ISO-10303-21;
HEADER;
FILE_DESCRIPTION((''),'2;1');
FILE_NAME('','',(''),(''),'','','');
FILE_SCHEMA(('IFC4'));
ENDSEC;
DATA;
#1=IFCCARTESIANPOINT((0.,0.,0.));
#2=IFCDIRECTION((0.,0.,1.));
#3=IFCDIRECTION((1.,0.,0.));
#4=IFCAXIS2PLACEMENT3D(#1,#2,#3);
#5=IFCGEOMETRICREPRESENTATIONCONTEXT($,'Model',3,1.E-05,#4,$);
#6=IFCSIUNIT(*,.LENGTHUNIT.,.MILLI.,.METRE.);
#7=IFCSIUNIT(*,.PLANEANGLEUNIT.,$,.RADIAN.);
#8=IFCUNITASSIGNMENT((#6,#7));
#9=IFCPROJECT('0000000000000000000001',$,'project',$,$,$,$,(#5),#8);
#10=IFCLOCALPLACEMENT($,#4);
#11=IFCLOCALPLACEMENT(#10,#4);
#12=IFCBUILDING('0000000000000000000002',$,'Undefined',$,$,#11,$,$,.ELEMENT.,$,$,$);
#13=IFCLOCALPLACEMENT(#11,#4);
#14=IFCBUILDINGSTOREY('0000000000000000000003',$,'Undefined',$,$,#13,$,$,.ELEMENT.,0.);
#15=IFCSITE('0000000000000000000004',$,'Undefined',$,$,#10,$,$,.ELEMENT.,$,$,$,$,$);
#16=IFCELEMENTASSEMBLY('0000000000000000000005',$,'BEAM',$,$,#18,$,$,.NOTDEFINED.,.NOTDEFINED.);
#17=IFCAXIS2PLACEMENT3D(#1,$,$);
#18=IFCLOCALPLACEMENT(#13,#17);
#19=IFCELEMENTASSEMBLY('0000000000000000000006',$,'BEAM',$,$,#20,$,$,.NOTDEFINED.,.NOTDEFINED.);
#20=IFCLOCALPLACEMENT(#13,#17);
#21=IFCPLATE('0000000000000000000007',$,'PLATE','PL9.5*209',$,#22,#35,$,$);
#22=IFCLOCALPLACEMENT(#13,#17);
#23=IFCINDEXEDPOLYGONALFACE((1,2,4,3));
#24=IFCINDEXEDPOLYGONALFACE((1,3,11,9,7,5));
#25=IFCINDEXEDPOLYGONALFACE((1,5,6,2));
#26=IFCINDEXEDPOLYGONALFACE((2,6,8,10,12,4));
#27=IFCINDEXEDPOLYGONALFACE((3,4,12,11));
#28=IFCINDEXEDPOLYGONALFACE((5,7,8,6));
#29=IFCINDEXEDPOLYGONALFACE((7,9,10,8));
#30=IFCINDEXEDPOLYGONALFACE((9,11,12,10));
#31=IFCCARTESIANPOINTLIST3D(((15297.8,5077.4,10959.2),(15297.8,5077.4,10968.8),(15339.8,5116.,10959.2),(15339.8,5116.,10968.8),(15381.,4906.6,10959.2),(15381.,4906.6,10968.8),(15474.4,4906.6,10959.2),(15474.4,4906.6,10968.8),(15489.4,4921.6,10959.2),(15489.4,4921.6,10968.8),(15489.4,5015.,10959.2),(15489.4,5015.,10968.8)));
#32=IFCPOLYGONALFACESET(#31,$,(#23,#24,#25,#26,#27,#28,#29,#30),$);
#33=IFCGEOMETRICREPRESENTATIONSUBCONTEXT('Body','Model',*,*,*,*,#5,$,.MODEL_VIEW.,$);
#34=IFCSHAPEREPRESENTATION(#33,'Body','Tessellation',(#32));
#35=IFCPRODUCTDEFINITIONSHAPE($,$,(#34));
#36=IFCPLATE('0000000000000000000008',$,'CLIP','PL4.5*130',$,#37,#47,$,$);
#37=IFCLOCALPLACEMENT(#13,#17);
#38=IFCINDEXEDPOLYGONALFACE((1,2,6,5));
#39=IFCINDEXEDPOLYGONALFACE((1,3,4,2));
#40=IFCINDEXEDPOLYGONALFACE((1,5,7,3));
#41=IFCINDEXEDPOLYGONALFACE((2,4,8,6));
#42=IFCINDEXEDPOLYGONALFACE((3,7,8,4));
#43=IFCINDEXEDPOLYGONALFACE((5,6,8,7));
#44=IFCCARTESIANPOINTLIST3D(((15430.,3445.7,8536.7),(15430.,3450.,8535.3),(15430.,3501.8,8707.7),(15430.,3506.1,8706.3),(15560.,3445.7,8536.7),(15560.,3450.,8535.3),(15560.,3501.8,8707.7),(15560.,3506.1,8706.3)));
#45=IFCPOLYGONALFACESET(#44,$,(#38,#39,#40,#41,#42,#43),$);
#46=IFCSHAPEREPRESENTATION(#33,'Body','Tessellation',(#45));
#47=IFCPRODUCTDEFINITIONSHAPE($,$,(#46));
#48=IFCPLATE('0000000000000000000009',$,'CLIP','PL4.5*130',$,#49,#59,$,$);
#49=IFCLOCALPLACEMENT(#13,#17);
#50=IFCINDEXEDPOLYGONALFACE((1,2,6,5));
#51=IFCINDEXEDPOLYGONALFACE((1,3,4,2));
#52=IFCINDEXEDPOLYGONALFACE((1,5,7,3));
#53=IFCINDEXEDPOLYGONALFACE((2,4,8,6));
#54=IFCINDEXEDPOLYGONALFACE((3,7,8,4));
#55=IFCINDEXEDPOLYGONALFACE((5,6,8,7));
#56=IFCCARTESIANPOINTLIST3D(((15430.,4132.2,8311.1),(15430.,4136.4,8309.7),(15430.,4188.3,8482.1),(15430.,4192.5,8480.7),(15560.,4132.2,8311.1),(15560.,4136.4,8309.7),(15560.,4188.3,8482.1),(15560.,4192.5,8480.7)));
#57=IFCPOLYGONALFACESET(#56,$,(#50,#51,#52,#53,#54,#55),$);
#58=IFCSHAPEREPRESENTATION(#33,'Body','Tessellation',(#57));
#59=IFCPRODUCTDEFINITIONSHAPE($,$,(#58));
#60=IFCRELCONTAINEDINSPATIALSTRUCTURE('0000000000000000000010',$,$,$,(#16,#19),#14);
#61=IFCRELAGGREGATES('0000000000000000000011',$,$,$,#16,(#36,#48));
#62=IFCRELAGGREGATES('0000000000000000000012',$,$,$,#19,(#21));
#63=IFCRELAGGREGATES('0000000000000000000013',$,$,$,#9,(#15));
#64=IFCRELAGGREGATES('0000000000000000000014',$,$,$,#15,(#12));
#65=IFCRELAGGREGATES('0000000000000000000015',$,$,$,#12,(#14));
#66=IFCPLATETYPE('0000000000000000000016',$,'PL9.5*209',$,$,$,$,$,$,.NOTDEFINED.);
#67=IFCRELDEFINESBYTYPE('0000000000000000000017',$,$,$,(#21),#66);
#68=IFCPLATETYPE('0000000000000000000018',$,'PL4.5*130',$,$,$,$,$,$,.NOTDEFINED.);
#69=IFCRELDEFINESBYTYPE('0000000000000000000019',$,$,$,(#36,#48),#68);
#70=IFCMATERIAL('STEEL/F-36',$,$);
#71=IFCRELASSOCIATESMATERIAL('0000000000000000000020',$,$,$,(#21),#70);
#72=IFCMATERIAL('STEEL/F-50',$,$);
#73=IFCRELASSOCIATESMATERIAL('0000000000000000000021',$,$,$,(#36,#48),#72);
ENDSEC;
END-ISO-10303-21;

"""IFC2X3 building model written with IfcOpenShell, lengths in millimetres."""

from ifc_helpers import new_model, si_unit, frame, origin_with_axes, place, context, subcontext, project, spatial, polyline, outline, extrude, material, type_object, element, aggregate, save


model = new_model("IFC2X3")

# Units and contexts
model_context = context("Model", 3, precision=1e-05, world=origin_with_axes())
body_context = subcontext(model_context, "Body", "Model", "MODEL_VIEW")
ifc_project = project(units=[si_unit("LENGTHUNIT", "METRE", prefix="MILLI"), si_unit("PLANEANGLEUNIT", "RADIAN")], contexts=[model_context])

# Site, building, storey
site_placement = place(None, origin_with_axes())
site = spatial("IfcSite", under=ifc_project, at=site_placement, Name="Undefined", CompositionType="ELEMENT")
building_placement = place(site_placement, origin_with_axes())
building = spatial("IfcBuilding", under=site, at=building_placement, Name="Undefined", CompositionType="ELEMENT")
storey_placement = place(building_placement, origin_with_axes())
storey = spatial("IfcBuildingStorey", under=building, at=storey_placement, Name="Undefined", CompositionType="ELEMENT", Elevation=0.0)

# Shared definitions
ifc_material_1 = material(Name="STEEL/F-36")

# Element assembly
assembly_1_placement = place(storey_placement, origin_with_axes())
assembly_1 = element("IfcElementAssembly", 1, at=assembly_1_placement, inside=storey, Name="BEAM", AssemblyPlace="NOTDEFINED", PredefinedType="NOTDEFINED")

# Element assembly
assembly_2_placement = place(storey_placement, origin_with_axes())
assembly_2 = element("IfcElementAssembly", 2, at=assembly_2_placement, inside=storey, Name="BEAM", AssemblyPlace="NOTDEFINED", PredefinedType="NOTDEFINED")

# Plates
plate_type_1 = type_object("IfcPlateType", Name="PL9.5*209", PredefinedType="NOTDEFINED")
plate_1_placement = place(assembly_2_placement, frame((15489.4, 5015.0, 10964.0), z_axis=(0.0, 0.0, -1.0), x_axis=(0.0, -1.0, 0.0)))
plate_1 = element("IfcPlate", 3, at=plate_1_placement, type_object=plate_type_1, material=ifc_material_1, Name="PLATE", Description="PL9.5*209", context=body_context, shape_type="SweptSolid", body=[
    extrude(outline(polyline([(0.0, 0.0), (93.4, 0.0), (108.4, 15.0), (108.4, 108.4), (-62.3, 191.6), (-100.9, 149.6), (0.0, 0.0)])), frame((0.0, 0.0, -4.8), z_axis=(0.0, 0.0, 1.0), x_axis=(1.0, 0.0, 0.0)), (0.0, 0.0, 1.0), 9.5),
])
ifc_material_2 = material(Name="STEEL/F-50")
plate_type_2 = type_object("IfcPlateType", Name="PL4.5*130", PredefinedType="NOTDEFINED")
plate_2_placement = place(assembly_1_placement, frame((15430.0, 3504.0, 8707.0), z_axis=(0.0, -0.950157, 0.311771), x_axis=(0.0, -0.311771, -0.950157)))
plate_2 = element("IfcPlate", 4, at=plate_2_placement, type_object=plate_type_2, material=ifc_material_2, Name="CLIP", Description="PL4.5*130", context=body_context, shape_type="SweptSolid", body=[
    extrude(outline(polyline([(0.0, 0.0), (180.0, 0.0), (180.0, 130.0), (0.0, 130.0), (0.0, 0.0)])), frame((0.0, 0.0, -2.2), z_axis=(0.0, 0.0, 1.0), x_axis=(1.0, 0.0, 0.0)), (0.0, 0.0, 1.0), 4.5),
])
plate_3_placement = place(assembly_1_placement, frame((15430.0, 4190.4, 8481.4), z_axis=(0.0, -0.950157, 0.311771), x_axis=(0.0, -0.311771, -0.950157)))
plate_3 = element("IfcPlate", 5, at=plate_3_placement, type_object=plate_type_2, material=ifc_material_2, Name="CLIP", Description="PL4.5*130", context=body_context, shape_type="SweptSolid", body=[
    extrude(outline(polyline([(0.0, 0.0), (180.0, 0.0), (180.0, 130.0), (0.0, 130.0), (0.0, 0.0)])), frame((0.0, 0.0, -2.2), z_axis=(0.0, 0.0, 1.0), x_axis=(1.0, 0.0, 0.0)), (0.0, 0.0, 1.0), 4.5),
])
aggregate(assembly_1, [plate_2, plate_3])

aggregate(assembly_2, [plate_1])

save(model, "model.ifc")
